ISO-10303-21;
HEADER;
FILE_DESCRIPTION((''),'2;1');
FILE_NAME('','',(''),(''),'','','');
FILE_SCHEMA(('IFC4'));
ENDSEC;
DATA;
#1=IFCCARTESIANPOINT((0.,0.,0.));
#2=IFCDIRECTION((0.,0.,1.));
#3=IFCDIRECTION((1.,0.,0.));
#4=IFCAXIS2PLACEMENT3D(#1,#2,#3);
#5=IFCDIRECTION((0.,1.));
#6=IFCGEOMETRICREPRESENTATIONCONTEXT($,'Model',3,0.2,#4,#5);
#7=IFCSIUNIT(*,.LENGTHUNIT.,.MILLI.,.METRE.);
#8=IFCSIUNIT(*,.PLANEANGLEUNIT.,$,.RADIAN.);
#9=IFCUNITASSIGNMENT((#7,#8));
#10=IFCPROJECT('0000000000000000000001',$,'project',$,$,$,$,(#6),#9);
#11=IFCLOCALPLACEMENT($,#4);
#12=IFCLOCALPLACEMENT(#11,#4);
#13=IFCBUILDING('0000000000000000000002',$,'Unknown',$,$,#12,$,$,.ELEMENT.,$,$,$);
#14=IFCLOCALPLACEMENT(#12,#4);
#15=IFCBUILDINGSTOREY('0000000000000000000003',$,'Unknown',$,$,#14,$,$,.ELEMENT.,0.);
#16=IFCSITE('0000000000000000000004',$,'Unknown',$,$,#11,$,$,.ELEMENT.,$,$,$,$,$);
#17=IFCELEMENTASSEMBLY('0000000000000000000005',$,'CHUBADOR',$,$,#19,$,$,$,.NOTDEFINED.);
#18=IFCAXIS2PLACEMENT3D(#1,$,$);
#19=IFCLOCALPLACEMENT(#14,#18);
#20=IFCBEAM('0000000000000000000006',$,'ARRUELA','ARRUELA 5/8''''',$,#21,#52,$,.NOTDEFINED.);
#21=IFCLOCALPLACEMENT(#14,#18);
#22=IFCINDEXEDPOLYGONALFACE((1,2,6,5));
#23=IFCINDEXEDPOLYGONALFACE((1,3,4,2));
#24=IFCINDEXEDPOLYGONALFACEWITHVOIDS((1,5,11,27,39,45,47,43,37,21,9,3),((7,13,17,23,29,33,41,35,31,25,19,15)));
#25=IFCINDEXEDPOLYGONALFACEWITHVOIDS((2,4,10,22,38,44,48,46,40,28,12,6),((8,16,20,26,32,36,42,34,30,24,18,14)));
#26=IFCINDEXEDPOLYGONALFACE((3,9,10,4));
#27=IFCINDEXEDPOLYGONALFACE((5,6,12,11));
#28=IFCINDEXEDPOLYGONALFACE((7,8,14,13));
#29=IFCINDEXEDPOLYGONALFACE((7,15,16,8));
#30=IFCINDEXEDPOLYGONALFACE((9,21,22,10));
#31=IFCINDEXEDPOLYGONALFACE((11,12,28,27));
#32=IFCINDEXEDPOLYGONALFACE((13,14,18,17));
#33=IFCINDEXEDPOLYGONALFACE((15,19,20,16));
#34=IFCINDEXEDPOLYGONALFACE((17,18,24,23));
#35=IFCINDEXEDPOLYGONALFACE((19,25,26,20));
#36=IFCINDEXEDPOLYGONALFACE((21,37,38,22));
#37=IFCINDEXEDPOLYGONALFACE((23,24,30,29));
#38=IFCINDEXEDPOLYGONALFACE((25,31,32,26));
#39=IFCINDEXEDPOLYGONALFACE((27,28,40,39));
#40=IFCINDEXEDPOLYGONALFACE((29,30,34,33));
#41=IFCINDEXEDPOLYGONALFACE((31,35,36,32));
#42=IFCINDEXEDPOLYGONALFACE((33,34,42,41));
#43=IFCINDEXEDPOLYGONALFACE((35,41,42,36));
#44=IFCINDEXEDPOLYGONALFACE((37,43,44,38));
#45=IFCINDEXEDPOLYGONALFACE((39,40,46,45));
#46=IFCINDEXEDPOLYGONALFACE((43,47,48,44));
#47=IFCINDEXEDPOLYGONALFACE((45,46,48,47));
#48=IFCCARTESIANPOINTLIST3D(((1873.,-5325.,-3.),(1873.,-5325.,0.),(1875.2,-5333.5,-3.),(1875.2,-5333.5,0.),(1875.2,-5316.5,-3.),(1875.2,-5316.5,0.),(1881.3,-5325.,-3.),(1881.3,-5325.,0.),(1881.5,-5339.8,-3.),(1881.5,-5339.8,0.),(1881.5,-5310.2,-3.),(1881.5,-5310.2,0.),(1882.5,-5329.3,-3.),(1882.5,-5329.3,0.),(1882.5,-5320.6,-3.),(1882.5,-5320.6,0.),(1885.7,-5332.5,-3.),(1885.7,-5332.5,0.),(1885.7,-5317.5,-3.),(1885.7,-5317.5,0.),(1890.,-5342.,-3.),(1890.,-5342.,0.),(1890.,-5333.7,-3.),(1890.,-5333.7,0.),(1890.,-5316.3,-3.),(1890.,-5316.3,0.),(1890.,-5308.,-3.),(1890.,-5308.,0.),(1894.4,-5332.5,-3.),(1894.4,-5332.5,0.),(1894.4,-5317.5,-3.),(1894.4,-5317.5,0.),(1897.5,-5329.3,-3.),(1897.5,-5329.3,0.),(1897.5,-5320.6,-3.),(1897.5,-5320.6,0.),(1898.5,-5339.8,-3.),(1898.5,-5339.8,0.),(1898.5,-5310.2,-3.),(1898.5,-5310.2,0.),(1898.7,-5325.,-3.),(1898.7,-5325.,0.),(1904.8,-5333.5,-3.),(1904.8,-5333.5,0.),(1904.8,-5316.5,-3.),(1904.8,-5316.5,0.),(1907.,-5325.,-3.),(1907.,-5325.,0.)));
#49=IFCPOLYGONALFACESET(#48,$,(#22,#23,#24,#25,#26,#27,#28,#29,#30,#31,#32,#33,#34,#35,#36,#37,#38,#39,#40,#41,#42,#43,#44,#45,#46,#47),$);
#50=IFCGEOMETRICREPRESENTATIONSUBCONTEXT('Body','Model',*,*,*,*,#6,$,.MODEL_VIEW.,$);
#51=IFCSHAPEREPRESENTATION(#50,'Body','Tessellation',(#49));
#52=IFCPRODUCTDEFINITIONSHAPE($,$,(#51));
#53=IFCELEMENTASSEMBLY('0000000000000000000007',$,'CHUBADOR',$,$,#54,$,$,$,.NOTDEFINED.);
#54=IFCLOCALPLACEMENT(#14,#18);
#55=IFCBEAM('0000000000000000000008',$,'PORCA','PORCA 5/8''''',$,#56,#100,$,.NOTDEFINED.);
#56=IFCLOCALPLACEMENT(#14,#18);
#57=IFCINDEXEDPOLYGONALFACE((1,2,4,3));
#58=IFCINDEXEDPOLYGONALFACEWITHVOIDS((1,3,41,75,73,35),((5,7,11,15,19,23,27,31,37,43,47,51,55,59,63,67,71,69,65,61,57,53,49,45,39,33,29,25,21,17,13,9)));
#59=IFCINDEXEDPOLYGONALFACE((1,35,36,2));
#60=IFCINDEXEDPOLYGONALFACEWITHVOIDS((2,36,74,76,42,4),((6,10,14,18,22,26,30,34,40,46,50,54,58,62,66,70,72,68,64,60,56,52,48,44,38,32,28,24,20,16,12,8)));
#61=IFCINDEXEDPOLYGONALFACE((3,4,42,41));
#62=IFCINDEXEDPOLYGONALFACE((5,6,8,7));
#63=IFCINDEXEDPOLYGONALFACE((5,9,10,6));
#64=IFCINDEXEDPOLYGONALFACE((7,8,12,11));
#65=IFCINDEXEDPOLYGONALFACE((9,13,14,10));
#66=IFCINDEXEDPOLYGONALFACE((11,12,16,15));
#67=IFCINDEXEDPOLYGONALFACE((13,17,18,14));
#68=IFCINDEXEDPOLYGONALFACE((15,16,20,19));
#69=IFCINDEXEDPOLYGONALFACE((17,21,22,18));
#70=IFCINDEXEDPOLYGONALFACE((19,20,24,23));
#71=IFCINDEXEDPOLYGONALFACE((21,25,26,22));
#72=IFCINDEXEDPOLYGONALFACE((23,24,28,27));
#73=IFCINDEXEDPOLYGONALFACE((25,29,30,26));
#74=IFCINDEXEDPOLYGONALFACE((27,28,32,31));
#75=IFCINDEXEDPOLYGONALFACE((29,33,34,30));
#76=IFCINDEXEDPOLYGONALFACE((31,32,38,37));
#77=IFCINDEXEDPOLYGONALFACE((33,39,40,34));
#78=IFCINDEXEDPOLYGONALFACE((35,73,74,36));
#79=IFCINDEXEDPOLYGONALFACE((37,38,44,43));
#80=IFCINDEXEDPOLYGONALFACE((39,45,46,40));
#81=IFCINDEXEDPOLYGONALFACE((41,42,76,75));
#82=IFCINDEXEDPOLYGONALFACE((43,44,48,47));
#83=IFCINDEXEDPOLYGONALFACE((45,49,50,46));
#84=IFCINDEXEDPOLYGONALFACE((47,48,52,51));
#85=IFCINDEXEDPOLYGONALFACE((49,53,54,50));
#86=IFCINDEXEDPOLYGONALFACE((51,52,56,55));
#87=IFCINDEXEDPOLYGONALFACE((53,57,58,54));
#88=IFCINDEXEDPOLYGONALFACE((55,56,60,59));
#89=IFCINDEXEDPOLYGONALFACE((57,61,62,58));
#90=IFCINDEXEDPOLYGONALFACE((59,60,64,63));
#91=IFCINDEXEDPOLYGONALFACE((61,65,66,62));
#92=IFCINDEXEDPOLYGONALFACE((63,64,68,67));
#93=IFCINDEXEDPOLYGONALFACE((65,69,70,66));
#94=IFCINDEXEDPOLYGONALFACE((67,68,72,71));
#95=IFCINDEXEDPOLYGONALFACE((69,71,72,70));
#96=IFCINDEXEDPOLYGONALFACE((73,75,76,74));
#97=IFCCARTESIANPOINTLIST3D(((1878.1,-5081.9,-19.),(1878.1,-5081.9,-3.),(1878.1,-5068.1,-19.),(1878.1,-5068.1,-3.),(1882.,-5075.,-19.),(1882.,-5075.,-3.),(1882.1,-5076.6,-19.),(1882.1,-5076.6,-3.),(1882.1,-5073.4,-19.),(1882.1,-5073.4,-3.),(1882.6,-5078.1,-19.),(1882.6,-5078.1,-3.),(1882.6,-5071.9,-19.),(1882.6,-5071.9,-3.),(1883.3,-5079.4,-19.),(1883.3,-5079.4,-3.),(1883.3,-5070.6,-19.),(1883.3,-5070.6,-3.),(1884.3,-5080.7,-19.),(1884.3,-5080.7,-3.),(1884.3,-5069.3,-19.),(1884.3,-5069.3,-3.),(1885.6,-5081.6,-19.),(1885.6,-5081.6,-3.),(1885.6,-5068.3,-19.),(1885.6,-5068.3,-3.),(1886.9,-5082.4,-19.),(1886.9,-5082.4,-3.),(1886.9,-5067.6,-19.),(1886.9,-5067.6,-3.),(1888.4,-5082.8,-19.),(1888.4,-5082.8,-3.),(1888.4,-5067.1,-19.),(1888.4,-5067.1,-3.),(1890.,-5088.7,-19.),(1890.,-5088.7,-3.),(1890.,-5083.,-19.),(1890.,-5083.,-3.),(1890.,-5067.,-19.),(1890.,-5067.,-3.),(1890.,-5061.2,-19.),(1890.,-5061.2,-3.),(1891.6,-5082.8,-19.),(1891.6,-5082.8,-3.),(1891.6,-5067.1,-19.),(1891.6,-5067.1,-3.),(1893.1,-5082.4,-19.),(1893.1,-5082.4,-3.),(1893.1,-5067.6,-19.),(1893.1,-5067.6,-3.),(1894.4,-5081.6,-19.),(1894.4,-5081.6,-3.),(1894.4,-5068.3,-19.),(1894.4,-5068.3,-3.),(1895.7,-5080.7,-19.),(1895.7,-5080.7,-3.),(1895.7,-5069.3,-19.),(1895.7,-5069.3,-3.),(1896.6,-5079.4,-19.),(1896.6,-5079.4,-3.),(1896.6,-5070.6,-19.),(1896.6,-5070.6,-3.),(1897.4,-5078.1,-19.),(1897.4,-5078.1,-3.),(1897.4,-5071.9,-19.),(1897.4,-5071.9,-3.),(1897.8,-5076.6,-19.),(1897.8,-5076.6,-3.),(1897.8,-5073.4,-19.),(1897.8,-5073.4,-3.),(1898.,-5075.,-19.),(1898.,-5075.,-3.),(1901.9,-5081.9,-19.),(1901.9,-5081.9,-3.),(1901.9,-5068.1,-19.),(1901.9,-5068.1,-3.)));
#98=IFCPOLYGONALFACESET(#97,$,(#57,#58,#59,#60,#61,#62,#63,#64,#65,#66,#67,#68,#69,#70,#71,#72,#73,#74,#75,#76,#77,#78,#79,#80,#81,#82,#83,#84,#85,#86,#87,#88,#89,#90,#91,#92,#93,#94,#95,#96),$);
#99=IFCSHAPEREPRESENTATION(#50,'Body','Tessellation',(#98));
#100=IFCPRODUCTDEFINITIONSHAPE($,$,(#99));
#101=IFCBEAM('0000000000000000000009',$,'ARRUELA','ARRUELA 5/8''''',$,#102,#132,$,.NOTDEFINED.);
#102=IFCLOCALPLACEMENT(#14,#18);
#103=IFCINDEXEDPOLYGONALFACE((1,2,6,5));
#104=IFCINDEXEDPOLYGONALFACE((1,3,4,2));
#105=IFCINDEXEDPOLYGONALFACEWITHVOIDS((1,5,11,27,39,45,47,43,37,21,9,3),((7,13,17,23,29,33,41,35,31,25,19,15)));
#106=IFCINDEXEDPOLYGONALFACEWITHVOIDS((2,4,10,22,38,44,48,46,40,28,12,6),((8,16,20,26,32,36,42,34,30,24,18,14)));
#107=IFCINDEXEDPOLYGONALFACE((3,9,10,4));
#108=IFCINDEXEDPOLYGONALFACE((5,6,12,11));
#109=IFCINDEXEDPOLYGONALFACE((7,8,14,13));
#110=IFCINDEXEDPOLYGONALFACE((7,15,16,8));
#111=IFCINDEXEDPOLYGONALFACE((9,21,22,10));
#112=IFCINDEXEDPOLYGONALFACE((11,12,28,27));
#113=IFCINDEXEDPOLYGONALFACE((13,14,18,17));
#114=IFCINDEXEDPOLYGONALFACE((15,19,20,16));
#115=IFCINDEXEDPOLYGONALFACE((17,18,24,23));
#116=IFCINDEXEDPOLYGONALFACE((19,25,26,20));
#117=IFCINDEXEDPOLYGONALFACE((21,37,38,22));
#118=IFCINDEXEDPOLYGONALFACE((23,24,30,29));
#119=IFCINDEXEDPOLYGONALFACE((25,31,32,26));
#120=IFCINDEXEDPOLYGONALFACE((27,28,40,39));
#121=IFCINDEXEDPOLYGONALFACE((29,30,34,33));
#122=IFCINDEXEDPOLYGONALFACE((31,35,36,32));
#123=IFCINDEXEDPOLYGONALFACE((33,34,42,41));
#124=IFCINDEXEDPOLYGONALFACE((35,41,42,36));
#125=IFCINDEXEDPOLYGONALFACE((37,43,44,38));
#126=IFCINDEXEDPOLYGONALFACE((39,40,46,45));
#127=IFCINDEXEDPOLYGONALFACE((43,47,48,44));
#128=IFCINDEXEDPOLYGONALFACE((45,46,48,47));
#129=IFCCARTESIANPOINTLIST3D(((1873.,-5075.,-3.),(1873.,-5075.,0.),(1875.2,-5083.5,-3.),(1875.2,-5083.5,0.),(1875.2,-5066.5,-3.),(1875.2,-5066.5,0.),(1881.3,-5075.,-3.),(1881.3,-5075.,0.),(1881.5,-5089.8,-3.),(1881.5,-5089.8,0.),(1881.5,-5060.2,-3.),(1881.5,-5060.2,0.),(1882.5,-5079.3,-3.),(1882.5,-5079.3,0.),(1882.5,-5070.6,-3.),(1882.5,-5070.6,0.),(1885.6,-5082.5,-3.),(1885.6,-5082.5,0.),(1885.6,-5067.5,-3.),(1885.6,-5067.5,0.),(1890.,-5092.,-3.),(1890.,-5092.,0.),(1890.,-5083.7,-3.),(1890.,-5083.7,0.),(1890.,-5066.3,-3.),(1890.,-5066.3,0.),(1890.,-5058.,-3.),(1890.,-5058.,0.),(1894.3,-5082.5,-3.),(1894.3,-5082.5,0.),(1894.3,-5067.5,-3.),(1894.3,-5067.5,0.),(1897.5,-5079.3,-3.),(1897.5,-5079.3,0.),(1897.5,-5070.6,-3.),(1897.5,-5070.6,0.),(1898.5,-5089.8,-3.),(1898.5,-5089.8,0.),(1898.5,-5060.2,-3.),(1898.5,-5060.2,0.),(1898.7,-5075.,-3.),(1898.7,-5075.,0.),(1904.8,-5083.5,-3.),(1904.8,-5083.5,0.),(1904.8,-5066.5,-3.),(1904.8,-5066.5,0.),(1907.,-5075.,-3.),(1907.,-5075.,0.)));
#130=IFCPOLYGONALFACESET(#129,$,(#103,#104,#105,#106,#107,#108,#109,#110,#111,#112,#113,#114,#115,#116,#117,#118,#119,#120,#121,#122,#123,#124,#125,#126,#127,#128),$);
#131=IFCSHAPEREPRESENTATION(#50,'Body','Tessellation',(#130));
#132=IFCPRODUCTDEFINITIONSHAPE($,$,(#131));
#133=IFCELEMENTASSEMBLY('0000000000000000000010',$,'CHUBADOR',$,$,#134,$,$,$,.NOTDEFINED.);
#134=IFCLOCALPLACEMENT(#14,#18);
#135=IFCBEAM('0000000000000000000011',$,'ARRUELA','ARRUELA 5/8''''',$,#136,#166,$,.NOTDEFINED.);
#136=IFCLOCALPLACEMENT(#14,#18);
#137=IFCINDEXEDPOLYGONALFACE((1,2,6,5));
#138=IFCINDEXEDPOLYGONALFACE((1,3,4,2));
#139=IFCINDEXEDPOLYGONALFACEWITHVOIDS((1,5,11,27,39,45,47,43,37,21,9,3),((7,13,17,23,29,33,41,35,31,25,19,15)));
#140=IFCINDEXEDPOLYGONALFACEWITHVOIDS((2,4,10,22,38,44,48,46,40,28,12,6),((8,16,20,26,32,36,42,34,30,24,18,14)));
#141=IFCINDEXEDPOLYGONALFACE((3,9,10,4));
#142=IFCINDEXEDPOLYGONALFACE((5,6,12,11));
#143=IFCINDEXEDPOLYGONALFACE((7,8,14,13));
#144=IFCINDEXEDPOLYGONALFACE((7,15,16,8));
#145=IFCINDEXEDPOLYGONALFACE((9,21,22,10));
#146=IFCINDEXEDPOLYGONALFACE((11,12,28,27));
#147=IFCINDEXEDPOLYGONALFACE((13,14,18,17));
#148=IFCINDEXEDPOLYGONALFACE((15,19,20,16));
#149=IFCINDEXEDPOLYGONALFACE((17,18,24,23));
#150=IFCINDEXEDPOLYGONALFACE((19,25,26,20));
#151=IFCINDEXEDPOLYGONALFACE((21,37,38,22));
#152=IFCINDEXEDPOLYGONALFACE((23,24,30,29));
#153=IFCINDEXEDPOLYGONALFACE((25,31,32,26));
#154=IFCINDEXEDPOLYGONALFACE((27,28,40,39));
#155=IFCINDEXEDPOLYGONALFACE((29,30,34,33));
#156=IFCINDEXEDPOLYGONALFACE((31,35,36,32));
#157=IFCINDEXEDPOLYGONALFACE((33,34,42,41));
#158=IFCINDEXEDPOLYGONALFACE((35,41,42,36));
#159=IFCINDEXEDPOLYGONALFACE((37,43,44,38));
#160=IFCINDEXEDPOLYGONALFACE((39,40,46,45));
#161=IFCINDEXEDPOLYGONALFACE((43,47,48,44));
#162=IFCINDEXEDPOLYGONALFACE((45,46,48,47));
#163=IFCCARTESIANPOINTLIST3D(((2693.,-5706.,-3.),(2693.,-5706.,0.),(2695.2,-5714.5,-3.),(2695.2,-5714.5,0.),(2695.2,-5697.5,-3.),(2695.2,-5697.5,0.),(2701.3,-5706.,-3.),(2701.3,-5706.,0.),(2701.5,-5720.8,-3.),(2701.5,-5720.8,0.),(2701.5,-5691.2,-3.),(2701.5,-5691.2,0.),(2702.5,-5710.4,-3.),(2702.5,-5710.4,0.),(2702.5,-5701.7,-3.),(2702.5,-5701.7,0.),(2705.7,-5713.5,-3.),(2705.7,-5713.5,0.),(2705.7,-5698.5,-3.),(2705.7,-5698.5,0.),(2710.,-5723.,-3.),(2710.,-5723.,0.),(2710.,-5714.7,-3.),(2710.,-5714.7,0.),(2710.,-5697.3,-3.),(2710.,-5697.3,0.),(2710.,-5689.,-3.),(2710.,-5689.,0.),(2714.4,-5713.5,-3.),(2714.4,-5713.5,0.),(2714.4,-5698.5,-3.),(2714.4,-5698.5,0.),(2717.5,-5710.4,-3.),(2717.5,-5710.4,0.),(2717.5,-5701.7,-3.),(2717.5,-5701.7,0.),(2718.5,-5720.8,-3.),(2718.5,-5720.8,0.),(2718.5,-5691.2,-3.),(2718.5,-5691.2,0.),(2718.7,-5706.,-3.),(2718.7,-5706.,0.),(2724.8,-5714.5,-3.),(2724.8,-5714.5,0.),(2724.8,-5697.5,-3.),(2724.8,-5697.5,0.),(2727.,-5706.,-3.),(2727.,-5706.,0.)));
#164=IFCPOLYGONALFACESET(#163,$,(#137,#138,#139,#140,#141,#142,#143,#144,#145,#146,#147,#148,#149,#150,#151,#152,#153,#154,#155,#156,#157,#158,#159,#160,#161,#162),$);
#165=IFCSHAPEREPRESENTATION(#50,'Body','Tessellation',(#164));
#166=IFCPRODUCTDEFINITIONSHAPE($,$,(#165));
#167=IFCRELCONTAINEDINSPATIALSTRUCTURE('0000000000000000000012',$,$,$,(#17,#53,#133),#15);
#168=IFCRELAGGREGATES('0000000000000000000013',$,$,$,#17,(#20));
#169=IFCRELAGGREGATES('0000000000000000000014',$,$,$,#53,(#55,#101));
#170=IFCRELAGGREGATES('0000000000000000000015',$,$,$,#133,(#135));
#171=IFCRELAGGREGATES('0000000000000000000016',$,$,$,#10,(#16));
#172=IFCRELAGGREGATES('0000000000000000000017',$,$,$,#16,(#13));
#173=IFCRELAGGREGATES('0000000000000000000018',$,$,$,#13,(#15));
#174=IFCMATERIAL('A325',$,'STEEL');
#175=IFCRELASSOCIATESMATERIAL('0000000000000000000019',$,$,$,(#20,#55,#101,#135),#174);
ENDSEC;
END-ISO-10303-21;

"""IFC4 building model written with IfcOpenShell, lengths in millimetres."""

from ifc_helpers import new_model, si_unit, direction, frame, origin_with_axes, place, context, subcontext, project, spatial, line, indexed_curve, outline, extrude, material, element, aggregate, save


model = new_model("IFC4")

# Units and contexts
model_context = context("Model", 3, precision=0.2, world=origin_with_axes(), true_north=direction((0.0, 1.0)))
body_context = subcontext(model_context, "Body", "Model", "MODEL_VIEW")
ifc_project = project(units=[si_unit("LENGTHUNIT", "METRE", prefix="MILLI"), si_unit("PLANEANGLEUNIT", "RADIAN")], contexts=[model_context])

# Site, building, storey
site_placement = place(None, origin_with_axes())
site = spatial("IfcSite", under=ifc_project, at=site_placement, Name="Unknown", CompositionType="ELEMENT")
building_placement = place(site_placement, origin_with_axes())
building = spatial("IfcBuilding", under=site, at=building_placement, Name="Unknown", CompositionType="ELEMENT")
storey_placement = place(building_placement, origin_with_axes())
storey = spatial("IfcBuildingStorey", under=building, at=storey_placement, Name="Unknown", CompositionType="ELEMENT", Elevation=0.0)

# Shared definitions
ifc_material_1 = material(Name="A325", Category="STEEL")

# Element assemblies, beams
assembly_1_placement = place(storey_placement, frame((1890.0, -5325.0, -52.1), z_axis=(1.0, 0.0, 0.0), x_axis=(0.0, 0.0, -1.0)))
assembly_1 = element("IfcElementAssembly", 1, at=assembly_1_placement, inside=storey, Name="CHUBADOR", PredefinedType="NOTDEFINED")
beam_1_placement = place(assembly_1_placement, frame((-52.1, 0.0, 0.0), z_axis=(0.0, 0.0, 1.0), x_axis=(1.0, 0.0, 0.0)))
beam_1 = element("IfcBeam", 2, at=beam_1_placement, material=ifc_material_1, Name="ARRUELA", Description="ARRUELA 5/8''", PredefinedType="NOTDEFINED", context=body_context, shape_type="SolidModel", body=[
    extrude(outline(indexed_curve([(17.0, 0.0), (14.8, 8.5), (8.5, 14.8), (0.0, 17.0), (-8.5, 14.8), (-14.8, 8.5), (-17.0, 0.0), (-14.8, -8.5), (-8.5, -14.8), (0.0, -17.0), (8.5, -14.8), (14.8, -8.5)], segments=[line(1, 2, 3, 4, 5, 6, 7, 8, 9, 10, 11, 12, 1)]), holes=[indexed_curve([(8.7, 0.0), (7.5, -4.3), (4.3, -7.5), (0.0, -8.7), (-4.3, -7.5), (-7.5, -4.3), (-8.7, 0.0), (-7.5, 4.3), (-4.3, 7.5), (0.0, 8.7), (4.3, 7.5), (7.5, 4.3)], segments=[line(1, 2, 3, 4, 5, 6, 7, 8, 9, 10, 11, 12, 1)])]), frame((0.0, 0.0, 0.0), z_axis=(-1.0, 0.0, 0.0), x_axis=(0.0, 0.0, 1.0)), (0.0, 0.0, -1.0), 3.0),
])
aggregate(assembly_1, [beam_1])
assembly_2_placement = place(storey_placement, frame((1890.0, -5075.0, -52.1), z_axis=(1.0, 0.0, 0.0), x_axis=(0.0, 0.0, -1.0)))
assembly_2 = element("IfcElementAssembly", 3, at=assembly_2_placement, inside=storey, Name="CHUBADOR", PredefinedType="NOTDEFINED")
beam_2_placement = place(assembly_2_placement, frame((-49.1, 0.0, 0.0), z_axis=(0.0, 0.0, 1.0), x_axis=(1.0, 0.0, 0.0)))
beam_2 = element("IfcBeam", 4, at=beam_2_placement, material=ifc_material_1, Name="PORCA", Description="PORCA 5/8''", PredefinedType="NOTDEFINED", context=body_context, shape_type="SolidModel", body=[
    extrude(outline(indexed_curve([(0.0, 13.8), (-11.9, 6.9), (-11.9, -6.9), (0.0, -13.8), (11.9, -6.9), (11.9, 6.9)], segments=[line(1, 2, 3, 4, 5, 6, 1)]), holes=[indexed_curve([(7.8, 1.6), (8.0, 0.0), (7.8, -1.6), (7.4, -3.1), (6.7, -4.4), (5.7, -5.7), (4.4, -6.7), (3.1, -7.4), (1.6, -7.8), (0.0, -8.0), (-1.6, -7.8), (-3.1, -7.4), (-4.4, -6.7), (-5.7, -5.7), (-6.7, -4.4), (-7.4, -3.1), (-7.8, -1.6), (-8.0, 0.0), (-7.8, 1.6), (-7.4, 3.1), (-6.7, 4.4), (-5.7, 5.7), (-4.4, 6.7), (-3.1, 7.4), (-1.6, 7.8), (0.0, 8.0), (1.6, 7.8), (3.1, 7.4), (4.4, 6.7), (5.7, 5.7), (6.7, 4.4), (7.4, 3.1)], segments=[line(1, 2, 3, 4, 5, 6, 7, 8, 9, 10, 11, 12, 13, 14, 15, 16, 17, 18, 19, 20, 21, 22, 23, 24, 25, 26, 27, 28, 29, 30, 31, 32, 1)])]), frame((0.0, 0.0, 0.0), z_axis=(-1.0, 0.0, 0.0), x_axis=(0.0, 0.0, 1.0)), (0.0, 0.0, -1.0), 16.0),
])
beam_3_placement = place(assembly_2_placement, frame((-52.1, 0.0, 0.0), z_axis=(0.0, 0.0, 1.0), x_axis=(1.0, 0.0, 0.0)))
beam_3 = element("IfcBeam", 5, at=beam_3_placement, material=ifc_material_1, Name="ARRUELA", Description="ARRUELA 5/8''", PredefinedType="NOTDEFINED", context=body_context, shape_type="SolidModel", body=[
    extrude(outline(indexed_curve([(17.0, 0.0), (14.8, 8.5), (8.5, 14.8), (0.0, 17.0), (-8.5, 14.8), (-14.8, 8.5), (-17.0, 0.0), (-14.8, -8.5), (-8.5, -14.8), (0.0, -17.0), (8.5, -14.8), (14.8, -8.5)], segments=[line(1, 2, 3, 4, 5, 6, 7, 8, 9, 10, 11, 12, 1)]), holes=[indexed_curve([(8.7, 0.0), (7.5, -4.3), (4.3, -7.5), (0.0, -8.7), (-4.3, -7.5), (-7.5, -4.3), (-8.7, 0.0), (-7.5, 4.3), (-4.3, 7.5), (0.0, 8.7), (4.3, 7.5), (7.5, 4.3)], segments=[line(1, 2, 3, 4, 5, 6, 7, 8, 9, 10, 11, 12, 1)])]), frame((0.0, 0.0, 0.0), z_axis=(-1.0, 0.0, 0.0), x_axis=(0.0, 0.0, 1.0)), (0.0, 0.0, -1.0), 3.0),
])
aggregate(assembly_2, [beam_2, beam_3])
assembly_3_placement = place(storey_placement, frame((2710.0, -5706.0, -52.1), z_axis=(-1.0, 0.0, 0.0), x_axis=(0.0, 0.0, -1.0)))
assembly_3 = element("IfcElementAssembly", 6, at=assembly_3_placement, inside=storey, Name="CHUBADOR", PredefinedType="NOTDEFINED")
beam_4_placement = place(assembly_3_placement, frame((-52.1, 0.0, 0.0), z_axis=(0.0, 0.0, 1.0), x_axis=(1.0, 0.0, 0.0)))
beam_4 = element("IfcBeam", 7, at=beam_4_placement, material=ifc_material_1, Name="ARRUELA", Description="ARRUELA 5/8''", PredefinedType="NOTDEFINED", context=body_context, shape_type="SolidModel", body=[
    extrude(outline(indexed_curve([(17.0, 0.0), (14.8, 8.5), (8.5, 14.8), (0.0, 17.0), (-8.5, 14.8), (-14.8, 8.5), (-17.0, 0.0), (-14.8, -8.5), (-8.5, -14.8), (0.0, -17.0), (8.5, -14.8), (14.8, -8.5)], segments=[line(1, 2, 3, 4, 5, 6, 7, 8, 9, 10, 11, 12, 1)]), holes=[indexed_curve([(8.7, 0.0), (7.5, -4.3), (4.3, -7.5), (0.0, -8.7), (-4.3, -7.5), (-7.5, -4.3), (-8.7, 0.0), (-7.5, 4.3), (-4.3, 7.5), (0.0, 8.7), (4.3, 7.5), (7.5, 4.3)], segments=[line(1, 2, 3, 4, 5, 6, 7, 8, 9, 10, 11, 12, 1)])]), frame((0.0, 0.0, 0.0), z_axis=(-1.0, 0.0, 0.0), x_axis=(0.0, 0.0, 1.0)), (0.0, 0.0, -1.0), 3.0),
])
aggregate(assembly_3, [beam_4])

save(model, "model.ifc")
